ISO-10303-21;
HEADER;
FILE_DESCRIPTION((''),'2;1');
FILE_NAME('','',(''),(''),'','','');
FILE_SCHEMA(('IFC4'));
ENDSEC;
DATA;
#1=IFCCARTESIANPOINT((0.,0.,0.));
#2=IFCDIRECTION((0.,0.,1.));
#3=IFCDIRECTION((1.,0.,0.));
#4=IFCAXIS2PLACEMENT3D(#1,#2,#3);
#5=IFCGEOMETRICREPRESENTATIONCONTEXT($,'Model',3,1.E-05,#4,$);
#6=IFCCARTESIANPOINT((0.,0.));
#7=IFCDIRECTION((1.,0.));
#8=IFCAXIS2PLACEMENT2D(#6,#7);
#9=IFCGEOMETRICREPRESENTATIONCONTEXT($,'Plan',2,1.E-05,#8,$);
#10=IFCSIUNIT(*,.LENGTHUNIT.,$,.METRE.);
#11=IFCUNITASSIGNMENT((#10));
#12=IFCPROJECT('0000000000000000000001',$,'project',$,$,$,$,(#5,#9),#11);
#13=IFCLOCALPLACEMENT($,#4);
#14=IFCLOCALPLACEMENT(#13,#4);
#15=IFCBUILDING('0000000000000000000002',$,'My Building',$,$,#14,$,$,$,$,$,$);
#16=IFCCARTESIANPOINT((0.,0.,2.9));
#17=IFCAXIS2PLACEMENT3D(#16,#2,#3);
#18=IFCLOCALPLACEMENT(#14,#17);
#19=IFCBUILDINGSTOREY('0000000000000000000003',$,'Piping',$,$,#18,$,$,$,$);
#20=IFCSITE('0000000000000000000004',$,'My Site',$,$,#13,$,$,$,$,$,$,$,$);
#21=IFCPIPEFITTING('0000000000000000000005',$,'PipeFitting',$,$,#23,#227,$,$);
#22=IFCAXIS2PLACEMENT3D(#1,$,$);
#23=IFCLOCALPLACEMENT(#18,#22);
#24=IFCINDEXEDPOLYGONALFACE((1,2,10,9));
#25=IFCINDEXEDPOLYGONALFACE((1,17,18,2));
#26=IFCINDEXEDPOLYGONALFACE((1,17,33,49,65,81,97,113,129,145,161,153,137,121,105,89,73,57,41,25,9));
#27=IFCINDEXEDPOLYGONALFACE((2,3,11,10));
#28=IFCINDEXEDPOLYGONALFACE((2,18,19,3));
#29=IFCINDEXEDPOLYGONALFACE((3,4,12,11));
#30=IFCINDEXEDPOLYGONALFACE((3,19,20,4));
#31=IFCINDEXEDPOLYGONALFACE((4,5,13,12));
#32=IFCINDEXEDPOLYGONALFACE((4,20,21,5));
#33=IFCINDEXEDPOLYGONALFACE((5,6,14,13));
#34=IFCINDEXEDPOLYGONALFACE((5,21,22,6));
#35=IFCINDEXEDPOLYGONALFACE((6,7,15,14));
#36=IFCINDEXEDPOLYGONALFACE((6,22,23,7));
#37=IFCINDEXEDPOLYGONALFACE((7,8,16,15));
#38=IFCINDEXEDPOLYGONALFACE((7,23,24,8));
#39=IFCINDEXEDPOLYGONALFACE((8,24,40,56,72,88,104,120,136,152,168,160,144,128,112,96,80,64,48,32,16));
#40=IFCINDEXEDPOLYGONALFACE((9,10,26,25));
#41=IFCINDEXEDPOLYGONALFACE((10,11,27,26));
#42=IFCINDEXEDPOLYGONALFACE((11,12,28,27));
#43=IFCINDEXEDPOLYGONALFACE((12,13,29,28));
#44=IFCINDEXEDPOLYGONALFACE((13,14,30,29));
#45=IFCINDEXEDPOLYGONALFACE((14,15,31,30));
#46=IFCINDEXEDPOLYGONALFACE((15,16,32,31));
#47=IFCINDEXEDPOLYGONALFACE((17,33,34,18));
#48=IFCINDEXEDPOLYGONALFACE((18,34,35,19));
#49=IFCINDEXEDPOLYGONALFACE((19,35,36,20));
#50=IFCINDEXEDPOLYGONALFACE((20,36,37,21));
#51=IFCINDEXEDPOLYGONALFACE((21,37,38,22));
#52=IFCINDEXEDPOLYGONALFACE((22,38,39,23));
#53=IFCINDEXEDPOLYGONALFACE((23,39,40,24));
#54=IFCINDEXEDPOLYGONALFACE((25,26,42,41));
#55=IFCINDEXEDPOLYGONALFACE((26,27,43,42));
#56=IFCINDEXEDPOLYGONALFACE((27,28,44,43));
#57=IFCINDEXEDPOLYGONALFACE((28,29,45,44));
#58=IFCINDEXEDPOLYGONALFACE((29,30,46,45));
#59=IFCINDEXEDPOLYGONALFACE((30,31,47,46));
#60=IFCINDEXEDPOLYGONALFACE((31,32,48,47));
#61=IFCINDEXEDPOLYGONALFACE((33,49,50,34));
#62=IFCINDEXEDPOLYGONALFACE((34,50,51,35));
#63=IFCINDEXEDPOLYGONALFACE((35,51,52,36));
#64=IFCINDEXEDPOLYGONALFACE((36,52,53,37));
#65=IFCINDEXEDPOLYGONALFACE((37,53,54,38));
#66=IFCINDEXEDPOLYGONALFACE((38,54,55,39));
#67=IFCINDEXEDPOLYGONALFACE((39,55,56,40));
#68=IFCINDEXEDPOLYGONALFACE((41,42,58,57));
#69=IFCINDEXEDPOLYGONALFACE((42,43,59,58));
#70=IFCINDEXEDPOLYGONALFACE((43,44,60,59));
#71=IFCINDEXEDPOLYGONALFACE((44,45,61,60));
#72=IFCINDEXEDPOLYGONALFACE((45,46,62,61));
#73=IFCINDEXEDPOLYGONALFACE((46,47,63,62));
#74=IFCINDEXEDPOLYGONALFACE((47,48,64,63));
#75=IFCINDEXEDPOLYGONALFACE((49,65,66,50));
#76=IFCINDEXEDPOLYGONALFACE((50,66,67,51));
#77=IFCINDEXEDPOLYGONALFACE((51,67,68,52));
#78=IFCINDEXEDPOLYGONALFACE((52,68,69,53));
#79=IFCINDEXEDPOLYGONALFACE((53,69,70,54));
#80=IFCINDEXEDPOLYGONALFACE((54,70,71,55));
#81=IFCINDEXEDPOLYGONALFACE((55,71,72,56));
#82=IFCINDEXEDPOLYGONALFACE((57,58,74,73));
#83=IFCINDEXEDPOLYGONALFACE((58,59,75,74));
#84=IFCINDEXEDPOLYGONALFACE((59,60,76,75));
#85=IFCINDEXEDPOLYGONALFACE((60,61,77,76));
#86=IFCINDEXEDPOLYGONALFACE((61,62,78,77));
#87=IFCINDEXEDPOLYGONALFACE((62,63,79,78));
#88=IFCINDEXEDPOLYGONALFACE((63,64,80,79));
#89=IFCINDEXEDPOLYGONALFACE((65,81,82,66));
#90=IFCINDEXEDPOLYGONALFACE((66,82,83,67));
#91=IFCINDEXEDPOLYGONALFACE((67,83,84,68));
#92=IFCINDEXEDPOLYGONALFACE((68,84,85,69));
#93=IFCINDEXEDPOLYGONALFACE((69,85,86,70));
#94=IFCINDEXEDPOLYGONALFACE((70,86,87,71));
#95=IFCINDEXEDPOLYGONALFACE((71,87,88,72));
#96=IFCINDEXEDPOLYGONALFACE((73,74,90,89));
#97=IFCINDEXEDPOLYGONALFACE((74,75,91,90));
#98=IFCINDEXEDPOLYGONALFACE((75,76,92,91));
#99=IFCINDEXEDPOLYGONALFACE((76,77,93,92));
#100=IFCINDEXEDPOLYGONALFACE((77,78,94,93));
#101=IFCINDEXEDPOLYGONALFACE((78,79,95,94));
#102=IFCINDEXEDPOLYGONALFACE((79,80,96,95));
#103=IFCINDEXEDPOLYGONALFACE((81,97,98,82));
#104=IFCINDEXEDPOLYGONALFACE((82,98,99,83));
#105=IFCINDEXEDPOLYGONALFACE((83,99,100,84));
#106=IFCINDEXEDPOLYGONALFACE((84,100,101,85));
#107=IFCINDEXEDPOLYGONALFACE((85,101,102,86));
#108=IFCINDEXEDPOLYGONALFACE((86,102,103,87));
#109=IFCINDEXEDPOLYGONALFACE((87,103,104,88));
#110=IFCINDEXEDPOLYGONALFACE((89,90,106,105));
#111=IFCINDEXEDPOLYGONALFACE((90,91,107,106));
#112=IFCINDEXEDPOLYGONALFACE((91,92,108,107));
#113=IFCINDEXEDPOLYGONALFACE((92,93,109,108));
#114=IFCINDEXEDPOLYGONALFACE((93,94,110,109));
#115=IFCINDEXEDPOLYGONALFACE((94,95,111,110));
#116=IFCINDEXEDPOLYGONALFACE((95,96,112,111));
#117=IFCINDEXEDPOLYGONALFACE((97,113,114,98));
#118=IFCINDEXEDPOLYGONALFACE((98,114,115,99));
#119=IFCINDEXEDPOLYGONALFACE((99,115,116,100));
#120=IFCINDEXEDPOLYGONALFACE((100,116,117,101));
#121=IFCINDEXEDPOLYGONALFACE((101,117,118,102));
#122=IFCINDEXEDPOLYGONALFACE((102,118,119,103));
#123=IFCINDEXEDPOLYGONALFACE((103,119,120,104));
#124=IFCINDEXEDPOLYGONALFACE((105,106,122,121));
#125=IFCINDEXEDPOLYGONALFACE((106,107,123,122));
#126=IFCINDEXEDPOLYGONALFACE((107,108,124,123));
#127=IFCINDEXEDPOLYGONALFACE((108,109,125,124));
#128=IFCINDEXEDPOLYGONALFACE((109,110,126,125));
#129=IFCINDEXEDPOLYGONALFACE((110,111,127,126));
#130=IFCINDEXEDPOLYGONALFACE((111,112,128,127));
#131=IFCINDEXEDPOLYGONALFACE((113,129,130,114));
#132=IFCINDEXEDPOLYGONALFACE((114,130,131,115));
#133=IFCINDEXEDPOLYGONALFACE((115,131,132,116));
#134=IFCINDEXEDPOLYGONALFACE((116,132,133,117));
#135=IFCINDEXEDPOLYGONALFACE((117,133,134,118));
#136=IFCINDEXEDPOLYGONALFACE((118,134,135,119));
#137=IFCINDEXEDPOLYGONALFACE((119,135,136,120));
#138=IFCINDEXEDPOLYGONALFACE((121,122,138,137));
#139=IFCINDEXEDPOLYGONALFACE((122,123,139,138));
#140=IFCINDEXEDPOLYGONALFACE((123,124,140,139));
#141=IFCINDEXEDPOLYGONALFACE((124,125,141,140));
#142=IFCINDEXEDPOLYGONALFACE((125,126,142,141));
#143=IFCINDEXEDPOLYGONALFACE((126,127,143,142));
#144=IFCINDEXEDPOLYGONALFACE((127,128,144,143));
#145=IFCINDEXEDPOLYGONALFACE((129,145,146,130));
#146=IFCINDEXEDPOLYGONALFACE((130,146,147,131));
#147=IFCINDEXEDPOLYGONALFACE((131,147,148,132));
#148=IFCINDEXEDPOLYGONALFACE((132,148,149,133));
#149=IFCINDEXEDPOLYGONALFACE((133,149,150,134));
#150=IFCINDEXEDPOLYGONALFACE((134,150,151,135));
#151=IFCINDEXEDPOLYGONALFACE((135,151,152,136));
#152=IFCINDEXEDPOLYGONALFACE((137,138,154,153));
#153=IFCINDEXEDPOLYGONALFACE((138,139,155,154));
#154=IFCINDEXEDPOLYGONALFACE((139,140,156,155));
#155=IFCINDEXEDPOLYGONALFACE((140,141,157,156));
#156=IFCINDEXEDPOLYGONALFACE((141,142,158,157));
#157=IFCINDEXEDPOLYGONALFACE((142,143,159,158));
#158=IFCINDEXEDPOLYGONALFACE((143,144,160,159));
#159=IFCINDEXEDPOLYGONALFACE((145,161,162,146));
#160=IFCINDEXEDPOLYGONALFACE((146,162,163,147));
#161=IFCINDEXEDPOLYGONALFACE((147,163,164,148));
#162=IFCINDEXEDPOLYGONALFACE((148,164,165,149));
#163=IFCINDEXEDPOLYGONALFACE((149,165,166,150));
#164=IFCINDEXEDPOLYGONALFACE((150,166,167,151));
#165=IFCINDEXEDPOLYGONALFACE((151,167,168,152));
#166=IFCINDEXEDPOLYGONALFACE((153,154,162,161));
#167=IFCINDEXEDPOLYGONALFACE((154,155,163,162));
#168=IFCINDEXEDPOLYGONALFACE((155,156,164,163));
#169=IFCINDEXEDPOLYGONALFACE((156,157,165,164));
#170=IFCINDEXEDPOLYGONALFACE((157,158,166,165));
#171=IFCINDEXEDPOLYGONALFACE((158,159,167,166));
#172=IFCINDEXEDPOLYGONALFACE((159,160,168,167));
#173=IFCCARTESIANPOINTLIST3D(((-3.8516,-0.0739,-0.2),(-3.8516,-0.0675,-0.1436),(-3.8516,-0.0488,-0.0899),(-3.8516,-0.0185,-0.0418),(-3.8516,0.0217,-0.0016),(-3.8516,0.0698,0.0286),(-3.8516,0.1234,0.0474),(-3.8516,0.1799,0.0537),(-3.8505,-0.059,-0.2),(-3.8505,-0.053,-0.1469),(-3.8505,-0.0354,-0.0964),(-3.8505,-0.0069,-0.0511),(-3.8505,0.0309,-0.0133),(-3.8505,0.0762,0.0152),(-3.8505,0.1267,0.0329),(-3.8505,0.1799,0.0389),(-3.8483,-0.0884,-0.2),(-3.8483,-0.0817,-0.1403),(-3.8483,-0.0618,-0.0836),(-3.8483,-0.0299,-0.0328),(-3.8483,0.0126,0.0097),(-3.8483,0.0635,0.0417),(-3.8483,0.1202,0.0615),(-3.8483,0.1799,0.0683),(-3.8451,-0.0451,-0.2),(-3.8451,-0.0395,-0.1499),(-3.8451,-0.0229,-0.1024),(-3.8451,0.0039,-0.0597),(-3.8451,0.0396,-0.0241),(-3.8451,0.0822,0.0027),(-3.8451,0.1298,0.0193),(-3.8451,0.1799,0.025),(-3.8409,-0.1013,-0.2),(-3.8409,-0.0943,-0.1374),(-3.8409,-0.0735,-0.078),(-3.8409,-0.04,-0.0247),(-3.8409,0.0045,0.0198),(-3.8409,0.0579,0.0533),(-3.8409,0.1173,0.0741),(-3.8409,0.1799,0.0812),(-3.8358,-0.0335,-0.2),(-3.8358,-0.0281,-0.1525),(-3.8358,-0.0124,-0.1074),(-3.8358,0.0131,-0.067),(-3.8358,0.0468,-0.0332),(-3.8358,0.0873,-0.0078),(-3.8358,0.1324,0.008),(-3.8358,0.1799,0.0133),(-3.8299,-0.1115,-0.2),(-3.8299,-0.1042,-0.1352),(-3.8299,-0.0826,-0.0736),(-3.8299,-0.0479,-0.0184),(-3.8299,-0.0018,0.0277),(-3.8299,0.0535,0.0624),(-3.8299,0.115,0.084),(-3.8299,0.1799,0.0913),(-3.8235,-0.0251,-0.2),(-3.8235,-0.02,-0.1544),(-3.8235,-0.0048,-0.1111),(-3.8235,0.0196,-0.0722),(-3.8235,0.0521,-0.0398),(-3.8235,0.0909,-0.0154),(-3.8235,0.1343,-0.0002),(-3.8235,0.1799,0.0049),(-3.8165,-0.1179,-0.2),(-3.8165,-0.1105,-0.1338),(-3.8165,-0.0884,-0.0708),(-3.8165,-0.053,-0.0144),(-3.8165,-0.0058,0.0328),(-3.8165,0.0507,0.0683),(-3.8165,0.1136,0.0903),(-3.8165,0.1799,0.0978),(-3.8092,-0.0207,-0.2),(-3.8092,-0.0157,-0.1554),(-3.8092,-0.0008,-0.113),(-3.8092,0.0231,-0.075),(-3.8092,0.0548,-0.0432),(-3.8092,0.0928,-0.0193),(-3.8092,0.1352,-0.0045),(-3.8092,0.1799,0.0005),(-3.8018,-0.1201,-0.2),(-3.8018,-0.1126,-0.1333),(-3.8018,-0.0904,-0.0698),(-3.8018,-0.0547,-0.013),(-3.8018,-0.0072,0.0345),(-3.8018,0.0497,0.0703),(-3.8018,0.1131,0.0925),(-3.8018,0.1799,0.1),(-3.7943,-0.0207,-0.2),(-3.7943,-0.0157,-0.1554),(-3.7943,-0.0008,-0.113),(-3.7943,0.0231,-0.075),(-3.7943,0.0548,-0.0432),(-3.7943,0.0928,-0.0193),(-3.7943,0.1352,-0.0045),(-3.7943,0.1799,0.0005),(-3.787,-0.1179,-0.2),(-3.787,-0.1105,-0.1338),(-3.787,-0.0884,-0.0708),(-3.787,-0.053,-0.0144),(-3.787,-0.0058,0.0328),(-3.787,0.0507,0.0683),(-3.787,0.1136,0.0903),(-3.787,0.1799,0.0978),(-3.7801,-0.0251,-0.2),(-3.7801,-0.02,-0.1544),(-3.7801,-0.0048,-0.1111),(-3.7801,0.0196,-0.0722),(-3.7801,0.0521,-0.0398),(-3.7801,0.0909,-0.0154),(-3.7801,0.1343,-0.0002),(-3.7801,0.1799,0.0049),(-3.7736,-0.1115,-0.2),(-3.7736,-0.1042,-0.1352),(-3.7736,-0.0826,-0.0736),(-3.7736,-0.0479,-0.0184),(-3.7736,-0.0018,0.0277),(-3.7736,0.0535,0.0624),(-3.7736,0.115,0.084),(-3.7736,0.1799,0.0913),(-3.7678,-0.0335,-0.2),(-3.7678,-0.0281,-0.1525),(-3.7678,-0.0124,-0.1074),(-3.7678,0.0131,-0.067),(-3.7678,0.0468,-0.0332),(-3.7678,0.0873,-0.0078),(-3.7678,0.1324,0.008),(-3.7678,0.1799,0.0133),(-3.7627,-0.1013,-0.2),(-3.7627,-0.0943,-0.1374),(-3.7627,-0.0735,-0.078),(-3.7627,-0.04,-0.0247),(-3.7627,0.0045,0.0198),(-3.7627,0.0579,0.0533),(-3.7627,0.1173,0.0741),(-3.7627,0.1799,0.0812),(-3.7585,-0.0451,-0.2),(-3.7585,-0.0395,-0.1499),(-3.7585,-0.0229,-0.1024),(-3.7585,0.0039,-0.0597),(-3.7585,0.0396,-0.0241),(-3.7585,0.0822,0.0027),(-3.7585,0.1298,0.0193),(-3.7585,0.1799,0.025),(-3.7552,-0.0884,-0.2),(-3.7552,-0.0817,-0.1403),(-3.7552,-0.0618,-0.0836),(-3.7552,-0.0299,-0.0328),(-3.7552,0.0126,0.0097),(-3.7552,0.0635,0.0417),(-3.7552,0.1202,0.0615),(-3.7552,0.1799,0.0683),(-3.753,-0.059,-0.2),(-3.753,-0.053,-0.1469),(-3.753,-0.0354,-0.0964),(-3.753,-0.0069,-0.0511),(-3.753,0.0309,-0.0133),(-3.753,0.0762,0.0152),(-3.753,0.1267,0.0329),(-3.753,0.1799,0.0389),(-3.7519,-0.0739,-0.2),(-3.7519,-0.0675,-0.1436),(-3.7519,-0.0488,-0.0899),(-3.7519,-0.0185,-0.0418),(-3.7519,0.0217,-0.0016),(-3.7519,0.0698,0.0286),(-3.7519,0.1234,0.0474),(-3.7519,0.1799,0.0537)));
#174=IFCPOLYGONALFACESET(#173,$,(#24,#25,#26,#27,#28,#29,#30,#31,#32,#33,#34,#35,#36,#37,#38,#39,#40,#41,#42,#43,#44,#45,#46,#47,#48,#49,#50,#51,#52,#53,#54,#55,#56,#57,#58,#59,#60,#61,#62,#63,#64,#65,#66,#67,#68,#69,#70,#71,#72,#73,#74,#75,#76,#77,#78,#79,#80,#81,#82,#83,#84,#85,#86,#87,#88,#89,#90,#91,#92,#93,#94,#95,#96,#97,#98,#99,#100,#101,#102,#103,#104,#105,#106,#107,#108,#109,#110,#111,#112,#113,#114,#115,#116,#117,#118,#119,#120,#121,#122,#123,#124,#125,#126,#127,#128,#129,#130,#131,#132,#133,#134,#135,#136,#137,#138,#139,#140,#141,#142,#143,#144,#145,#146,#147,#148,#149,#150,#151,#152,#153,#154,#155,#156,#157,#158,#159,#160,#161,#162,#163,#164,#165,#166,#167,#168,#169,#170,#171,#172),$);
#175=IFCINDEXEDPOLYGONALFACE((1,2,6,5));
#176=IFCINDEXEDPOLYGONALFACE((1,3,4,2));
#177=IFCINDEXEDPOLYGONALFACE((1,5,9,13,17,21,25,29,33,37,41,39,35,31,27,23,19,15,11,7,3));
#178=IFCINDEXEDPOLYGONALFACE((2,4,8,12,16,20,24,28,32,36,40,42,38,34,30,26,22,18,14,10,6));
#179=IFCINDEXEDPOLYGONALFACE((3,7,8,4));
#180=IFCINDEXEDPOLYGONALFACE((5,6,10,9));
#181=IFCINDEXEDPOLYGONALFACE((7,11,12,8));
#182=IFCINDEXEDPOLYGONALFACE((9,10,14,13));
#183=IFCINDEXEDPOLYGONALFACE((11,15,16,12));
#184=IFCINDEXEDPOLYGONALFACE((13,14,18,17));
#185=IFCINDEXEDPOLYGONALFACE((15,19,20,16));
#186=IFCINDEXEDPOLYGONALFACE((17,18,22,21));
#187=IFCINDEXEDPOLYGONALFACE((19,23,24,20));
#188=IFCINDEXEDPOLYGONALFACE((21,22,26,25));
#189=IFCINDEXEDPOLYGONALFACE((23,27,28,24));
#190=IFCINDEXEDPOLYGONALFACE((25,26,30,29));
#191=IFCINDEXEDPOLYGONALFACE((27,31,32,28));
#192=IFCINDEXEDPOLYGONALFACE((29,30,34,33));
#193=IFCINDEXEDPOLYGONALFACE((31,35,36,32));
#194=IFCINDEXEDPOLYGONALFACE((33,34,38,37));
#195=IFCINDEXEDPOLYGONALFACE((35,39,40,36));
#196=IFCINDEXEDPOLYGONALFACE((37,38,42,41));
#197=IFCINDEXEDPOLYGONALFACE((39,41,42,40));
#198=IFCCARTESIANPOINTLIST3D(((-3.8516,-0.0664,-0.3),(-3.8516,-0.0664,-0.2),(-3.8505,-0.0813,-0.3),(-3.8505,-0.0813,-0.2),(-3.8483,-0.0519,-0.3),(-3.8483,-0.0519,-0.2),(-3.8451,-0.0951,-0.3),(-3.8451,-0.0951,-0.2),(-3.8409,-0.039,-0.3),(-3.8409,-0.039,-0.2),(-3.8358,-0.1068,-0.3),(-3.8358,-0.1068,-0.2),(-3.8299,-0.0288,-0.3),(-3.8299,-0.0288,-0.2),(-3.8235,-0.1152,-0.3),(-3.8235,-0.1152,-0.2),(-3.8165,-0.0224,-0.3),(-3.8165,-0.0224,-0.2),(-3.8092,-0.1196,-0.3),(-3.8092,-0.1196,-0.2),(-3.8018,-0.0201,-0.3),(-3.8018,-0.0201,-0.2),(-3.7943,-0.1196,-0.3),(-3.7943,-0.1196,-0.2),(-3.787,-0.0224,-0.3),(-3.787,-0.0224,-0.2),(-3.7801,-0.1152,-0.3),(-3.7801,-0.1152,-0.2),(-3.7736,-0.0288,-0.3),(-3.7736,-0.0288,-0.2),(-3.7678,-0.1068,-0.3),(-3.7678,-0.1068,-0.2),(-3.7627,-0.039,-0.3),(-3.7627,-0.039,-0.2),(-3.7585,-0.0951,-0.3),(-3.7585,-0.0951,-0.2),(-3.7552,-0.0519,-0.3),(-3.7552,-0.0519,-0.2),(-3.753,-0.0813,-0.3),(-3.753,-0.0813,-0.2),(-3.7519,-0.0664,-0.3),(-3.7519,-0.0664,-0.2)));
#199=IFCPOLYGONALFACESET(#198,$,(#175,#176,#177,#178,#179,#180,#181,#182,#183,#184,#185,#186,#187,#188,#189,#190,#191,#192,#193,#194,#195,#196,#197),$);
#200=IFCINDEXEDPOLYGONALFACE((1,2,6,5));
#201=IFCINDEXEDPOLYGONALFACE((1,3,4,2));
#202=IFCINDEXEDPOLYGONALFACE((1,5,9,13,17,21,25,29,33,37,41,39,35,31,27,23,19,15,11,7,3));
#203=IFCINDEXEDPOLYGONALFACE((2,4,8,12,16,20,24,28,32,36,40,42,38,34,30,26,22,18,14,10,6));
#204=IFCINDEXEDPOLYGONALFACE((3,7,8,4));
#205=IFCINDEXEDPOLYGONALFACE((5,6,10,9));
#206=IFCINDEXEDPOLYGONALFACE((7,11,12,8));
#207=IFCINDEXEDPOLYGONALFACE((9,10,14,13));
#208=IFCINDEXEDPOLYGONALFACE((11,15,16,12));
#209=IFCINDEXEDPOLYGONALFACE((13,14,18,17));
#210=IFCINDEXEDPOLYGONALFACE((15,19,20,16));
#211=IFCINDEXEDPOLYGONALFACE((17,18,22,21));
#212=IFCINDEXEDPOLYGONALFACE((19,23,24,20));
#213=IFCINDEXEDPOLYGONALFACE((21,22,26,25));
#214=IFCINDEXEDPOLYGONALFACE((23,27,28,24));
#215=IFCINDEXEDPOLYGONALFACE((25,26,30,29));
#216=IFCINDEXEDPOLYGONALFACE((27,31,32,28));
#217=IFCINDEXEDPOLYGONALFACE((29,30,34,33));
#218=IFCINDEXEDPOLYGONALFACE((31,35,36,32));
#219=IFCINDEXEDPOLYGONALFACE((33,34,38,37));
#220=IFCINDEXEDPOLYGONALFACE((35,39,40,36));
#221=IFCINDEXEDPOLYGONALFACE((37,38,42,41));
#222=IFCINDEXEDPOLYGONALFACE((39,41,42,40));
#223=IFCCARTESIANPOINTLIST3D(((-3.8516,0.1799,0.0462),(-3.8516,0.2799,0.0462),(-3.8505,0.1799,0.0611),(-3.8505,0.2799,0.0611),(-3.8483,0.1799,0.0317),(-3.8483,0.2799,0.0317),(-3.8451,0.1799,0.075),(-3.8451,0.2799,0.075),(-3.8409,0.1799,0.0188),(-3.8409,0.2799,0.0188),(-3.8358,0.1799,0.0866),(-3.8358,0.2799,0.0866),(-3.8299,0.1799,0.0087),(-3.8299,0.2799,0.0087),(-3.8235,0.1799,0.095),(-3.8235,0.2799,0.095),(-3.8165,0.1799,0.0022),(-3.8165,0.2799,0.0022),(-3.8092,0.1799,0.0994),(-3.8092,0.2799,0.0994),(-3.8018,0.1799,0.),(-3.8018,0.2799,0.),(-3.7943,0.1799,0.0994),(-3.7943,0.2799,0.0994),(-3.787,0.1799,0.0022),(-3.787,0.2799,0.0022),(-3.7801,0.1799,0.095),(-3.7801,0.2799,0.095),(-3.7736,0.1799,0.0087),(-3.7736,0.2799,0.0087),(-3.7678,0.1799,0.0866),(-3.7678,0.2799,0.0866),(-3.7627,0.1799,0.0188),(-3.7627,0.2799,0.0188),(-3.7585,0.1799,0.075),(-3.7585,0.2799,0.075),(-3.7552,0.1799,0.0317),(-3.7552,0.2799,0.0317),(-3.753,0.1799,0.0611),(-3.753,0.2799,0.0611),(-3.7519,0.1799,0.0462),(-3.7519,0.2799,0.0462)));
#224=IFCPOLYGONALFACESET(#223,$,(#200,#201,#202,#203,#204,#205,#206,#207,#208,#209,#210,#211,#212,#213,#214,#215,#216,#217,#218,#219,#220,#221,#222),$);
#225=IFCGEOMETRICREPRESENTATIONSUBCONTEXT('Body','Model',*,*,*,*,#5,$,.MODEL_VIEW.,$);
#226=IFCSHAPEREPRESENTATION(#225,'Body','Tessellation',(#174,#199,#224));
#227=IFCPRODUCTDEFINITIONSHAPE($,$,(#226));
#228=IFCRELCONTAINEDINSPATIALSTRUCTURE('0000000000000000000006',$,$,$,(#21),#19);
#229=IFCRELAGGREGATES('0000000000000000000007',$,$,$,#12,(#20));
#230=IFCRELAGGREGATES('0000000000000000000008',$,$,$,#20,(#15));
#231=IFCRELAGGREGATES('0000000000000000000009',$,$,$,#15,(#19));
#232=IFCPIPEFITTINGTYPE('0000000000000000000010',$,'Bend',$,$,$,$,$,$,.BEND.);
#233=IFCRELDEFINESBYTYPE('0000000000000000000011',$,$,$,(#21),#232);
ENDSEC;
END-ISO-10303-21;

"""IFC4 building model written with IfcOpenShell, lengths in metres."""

from ifc_helpers import new_model, entity, si_unit, frame, origin_with_axes, origin_2d_with_axis, place, context, subcontext, project, spatial, line, indexed_curve, circle, outline, extrude, source, transform, mapped, type_object, type_shapes, element, save


model = new_model("IFC4")

# Units and contexts
model_context = context("Model", 3, precision=1e-05, world=origin_with_axes())
plan_context = context("Plan", 2, precision=1e-05, world=origin_2d_with_axis())
body_context = subcontext(model_context, "Body", "Model", "MODEL_VIEW")
ifc_project = project(units=[si_unit("LENGTHUNIT", "METRE")], contexts=[model_context, plan_context])

# Site, building, storey
site_placement = place(None, origin_with_axes())
site = spatial("IfcSite", under=ifc_project, at=site_placement, Name="My Site")
building_placement = place(site_placement, origin_with_axes())
building = spatial("IfcBuilding", under=site, at=building_placement, Name="My Building")
storey_placement = place(building_placement, frame((0.0, 0.0, 2.9), z_axis=(0.0, 0.0, 1.0), x_axis=(1.0, 0.0, 0.0)))
storey = spatial("IfcBuildingStorey", under=building, at=storey_placement, Name="Piping")

# Shared definitions
pipe_fitting_type_1 = type_object("IfcPipeFittingType", Name="Bend", PredefinedType="BEND")
shared_shape = source(origin_with_axes(), body_context, "Body", "SolidModel", [
    entity("IfcSweptDiskSolid", entity("IfcIndexedPolyCurve", entity("IfcCartesianPointList3D", [[0.0, 0.0, -0.1], [0.0732, 0.0, -0.2768], [0.25, 0.0, -0.35]]), [entity("IfcArcIndex", [1, 2, 3])]), 0.05),
    extrude(circle(Radius=0.05), origin_with_axes(), (0.0, 0.0, -1.0), 0.1),
    extrude(circle(Radius=0.05), frame((0.25, 0.0, -0.35), z_axis=(1.0, 0.0, 0.0), x_axis=(0.0, 0.0, 1.0)), (0.0, 0.0, 1.0), 0.1),
])
type_shapes(pipe_fitting_type_1, [shared_shape])

# Pipe fitting, opening
pipe_fitting_1_placement = place(storey_placement, frame((-3.8018, -0.0701, -0.3), z_axis=(0.0, 0.0, -1.0), x_axis=(0.0, 1.0, 0.0)))
pipe_fitting_1 = element("IfcPipeFitting", 1, at=pipe_fitting_1_placement, inside=storey, type_object=pipe_fitting_type_1, Name="PipeFitting", context=body_context, shape_type="MappedRepresentation", body=[
    mapped(shared_shape, transform((0.0, 0.0, 0.0), x_axis=(1.0, 0.0, 0.0), y_axis=(0.0, 1.0, 0.0), z_axis=(0.0, 0.0, 1.0), scale=1.0)),
])
opening_1_placement = place(pipe_fitting_1_placement, frame((0.0701, 3.8018, 2.6), z_axis=(0.0, 0.0, -1.0), x_axis=(0.0, 1.0, 0.0)))
element("IfcOpeningElement", 2, at=opening_1_placement, cuts=pipe_fitting_1, PredefinedType="OPENING", context=body_context, shape_type="SweptSolid", body=[
    extrude(outline(indexed_curve([(0.0, 0.0), (0.5, 0.0), (0.5, 0.5), (0.0, 0.5)], segments=[line(1, 2, 3, 4, 1)])), origin_with_axes(), (0.0, 0.0, 1.0), 0.5),
])

save(model, "model.ifc")
